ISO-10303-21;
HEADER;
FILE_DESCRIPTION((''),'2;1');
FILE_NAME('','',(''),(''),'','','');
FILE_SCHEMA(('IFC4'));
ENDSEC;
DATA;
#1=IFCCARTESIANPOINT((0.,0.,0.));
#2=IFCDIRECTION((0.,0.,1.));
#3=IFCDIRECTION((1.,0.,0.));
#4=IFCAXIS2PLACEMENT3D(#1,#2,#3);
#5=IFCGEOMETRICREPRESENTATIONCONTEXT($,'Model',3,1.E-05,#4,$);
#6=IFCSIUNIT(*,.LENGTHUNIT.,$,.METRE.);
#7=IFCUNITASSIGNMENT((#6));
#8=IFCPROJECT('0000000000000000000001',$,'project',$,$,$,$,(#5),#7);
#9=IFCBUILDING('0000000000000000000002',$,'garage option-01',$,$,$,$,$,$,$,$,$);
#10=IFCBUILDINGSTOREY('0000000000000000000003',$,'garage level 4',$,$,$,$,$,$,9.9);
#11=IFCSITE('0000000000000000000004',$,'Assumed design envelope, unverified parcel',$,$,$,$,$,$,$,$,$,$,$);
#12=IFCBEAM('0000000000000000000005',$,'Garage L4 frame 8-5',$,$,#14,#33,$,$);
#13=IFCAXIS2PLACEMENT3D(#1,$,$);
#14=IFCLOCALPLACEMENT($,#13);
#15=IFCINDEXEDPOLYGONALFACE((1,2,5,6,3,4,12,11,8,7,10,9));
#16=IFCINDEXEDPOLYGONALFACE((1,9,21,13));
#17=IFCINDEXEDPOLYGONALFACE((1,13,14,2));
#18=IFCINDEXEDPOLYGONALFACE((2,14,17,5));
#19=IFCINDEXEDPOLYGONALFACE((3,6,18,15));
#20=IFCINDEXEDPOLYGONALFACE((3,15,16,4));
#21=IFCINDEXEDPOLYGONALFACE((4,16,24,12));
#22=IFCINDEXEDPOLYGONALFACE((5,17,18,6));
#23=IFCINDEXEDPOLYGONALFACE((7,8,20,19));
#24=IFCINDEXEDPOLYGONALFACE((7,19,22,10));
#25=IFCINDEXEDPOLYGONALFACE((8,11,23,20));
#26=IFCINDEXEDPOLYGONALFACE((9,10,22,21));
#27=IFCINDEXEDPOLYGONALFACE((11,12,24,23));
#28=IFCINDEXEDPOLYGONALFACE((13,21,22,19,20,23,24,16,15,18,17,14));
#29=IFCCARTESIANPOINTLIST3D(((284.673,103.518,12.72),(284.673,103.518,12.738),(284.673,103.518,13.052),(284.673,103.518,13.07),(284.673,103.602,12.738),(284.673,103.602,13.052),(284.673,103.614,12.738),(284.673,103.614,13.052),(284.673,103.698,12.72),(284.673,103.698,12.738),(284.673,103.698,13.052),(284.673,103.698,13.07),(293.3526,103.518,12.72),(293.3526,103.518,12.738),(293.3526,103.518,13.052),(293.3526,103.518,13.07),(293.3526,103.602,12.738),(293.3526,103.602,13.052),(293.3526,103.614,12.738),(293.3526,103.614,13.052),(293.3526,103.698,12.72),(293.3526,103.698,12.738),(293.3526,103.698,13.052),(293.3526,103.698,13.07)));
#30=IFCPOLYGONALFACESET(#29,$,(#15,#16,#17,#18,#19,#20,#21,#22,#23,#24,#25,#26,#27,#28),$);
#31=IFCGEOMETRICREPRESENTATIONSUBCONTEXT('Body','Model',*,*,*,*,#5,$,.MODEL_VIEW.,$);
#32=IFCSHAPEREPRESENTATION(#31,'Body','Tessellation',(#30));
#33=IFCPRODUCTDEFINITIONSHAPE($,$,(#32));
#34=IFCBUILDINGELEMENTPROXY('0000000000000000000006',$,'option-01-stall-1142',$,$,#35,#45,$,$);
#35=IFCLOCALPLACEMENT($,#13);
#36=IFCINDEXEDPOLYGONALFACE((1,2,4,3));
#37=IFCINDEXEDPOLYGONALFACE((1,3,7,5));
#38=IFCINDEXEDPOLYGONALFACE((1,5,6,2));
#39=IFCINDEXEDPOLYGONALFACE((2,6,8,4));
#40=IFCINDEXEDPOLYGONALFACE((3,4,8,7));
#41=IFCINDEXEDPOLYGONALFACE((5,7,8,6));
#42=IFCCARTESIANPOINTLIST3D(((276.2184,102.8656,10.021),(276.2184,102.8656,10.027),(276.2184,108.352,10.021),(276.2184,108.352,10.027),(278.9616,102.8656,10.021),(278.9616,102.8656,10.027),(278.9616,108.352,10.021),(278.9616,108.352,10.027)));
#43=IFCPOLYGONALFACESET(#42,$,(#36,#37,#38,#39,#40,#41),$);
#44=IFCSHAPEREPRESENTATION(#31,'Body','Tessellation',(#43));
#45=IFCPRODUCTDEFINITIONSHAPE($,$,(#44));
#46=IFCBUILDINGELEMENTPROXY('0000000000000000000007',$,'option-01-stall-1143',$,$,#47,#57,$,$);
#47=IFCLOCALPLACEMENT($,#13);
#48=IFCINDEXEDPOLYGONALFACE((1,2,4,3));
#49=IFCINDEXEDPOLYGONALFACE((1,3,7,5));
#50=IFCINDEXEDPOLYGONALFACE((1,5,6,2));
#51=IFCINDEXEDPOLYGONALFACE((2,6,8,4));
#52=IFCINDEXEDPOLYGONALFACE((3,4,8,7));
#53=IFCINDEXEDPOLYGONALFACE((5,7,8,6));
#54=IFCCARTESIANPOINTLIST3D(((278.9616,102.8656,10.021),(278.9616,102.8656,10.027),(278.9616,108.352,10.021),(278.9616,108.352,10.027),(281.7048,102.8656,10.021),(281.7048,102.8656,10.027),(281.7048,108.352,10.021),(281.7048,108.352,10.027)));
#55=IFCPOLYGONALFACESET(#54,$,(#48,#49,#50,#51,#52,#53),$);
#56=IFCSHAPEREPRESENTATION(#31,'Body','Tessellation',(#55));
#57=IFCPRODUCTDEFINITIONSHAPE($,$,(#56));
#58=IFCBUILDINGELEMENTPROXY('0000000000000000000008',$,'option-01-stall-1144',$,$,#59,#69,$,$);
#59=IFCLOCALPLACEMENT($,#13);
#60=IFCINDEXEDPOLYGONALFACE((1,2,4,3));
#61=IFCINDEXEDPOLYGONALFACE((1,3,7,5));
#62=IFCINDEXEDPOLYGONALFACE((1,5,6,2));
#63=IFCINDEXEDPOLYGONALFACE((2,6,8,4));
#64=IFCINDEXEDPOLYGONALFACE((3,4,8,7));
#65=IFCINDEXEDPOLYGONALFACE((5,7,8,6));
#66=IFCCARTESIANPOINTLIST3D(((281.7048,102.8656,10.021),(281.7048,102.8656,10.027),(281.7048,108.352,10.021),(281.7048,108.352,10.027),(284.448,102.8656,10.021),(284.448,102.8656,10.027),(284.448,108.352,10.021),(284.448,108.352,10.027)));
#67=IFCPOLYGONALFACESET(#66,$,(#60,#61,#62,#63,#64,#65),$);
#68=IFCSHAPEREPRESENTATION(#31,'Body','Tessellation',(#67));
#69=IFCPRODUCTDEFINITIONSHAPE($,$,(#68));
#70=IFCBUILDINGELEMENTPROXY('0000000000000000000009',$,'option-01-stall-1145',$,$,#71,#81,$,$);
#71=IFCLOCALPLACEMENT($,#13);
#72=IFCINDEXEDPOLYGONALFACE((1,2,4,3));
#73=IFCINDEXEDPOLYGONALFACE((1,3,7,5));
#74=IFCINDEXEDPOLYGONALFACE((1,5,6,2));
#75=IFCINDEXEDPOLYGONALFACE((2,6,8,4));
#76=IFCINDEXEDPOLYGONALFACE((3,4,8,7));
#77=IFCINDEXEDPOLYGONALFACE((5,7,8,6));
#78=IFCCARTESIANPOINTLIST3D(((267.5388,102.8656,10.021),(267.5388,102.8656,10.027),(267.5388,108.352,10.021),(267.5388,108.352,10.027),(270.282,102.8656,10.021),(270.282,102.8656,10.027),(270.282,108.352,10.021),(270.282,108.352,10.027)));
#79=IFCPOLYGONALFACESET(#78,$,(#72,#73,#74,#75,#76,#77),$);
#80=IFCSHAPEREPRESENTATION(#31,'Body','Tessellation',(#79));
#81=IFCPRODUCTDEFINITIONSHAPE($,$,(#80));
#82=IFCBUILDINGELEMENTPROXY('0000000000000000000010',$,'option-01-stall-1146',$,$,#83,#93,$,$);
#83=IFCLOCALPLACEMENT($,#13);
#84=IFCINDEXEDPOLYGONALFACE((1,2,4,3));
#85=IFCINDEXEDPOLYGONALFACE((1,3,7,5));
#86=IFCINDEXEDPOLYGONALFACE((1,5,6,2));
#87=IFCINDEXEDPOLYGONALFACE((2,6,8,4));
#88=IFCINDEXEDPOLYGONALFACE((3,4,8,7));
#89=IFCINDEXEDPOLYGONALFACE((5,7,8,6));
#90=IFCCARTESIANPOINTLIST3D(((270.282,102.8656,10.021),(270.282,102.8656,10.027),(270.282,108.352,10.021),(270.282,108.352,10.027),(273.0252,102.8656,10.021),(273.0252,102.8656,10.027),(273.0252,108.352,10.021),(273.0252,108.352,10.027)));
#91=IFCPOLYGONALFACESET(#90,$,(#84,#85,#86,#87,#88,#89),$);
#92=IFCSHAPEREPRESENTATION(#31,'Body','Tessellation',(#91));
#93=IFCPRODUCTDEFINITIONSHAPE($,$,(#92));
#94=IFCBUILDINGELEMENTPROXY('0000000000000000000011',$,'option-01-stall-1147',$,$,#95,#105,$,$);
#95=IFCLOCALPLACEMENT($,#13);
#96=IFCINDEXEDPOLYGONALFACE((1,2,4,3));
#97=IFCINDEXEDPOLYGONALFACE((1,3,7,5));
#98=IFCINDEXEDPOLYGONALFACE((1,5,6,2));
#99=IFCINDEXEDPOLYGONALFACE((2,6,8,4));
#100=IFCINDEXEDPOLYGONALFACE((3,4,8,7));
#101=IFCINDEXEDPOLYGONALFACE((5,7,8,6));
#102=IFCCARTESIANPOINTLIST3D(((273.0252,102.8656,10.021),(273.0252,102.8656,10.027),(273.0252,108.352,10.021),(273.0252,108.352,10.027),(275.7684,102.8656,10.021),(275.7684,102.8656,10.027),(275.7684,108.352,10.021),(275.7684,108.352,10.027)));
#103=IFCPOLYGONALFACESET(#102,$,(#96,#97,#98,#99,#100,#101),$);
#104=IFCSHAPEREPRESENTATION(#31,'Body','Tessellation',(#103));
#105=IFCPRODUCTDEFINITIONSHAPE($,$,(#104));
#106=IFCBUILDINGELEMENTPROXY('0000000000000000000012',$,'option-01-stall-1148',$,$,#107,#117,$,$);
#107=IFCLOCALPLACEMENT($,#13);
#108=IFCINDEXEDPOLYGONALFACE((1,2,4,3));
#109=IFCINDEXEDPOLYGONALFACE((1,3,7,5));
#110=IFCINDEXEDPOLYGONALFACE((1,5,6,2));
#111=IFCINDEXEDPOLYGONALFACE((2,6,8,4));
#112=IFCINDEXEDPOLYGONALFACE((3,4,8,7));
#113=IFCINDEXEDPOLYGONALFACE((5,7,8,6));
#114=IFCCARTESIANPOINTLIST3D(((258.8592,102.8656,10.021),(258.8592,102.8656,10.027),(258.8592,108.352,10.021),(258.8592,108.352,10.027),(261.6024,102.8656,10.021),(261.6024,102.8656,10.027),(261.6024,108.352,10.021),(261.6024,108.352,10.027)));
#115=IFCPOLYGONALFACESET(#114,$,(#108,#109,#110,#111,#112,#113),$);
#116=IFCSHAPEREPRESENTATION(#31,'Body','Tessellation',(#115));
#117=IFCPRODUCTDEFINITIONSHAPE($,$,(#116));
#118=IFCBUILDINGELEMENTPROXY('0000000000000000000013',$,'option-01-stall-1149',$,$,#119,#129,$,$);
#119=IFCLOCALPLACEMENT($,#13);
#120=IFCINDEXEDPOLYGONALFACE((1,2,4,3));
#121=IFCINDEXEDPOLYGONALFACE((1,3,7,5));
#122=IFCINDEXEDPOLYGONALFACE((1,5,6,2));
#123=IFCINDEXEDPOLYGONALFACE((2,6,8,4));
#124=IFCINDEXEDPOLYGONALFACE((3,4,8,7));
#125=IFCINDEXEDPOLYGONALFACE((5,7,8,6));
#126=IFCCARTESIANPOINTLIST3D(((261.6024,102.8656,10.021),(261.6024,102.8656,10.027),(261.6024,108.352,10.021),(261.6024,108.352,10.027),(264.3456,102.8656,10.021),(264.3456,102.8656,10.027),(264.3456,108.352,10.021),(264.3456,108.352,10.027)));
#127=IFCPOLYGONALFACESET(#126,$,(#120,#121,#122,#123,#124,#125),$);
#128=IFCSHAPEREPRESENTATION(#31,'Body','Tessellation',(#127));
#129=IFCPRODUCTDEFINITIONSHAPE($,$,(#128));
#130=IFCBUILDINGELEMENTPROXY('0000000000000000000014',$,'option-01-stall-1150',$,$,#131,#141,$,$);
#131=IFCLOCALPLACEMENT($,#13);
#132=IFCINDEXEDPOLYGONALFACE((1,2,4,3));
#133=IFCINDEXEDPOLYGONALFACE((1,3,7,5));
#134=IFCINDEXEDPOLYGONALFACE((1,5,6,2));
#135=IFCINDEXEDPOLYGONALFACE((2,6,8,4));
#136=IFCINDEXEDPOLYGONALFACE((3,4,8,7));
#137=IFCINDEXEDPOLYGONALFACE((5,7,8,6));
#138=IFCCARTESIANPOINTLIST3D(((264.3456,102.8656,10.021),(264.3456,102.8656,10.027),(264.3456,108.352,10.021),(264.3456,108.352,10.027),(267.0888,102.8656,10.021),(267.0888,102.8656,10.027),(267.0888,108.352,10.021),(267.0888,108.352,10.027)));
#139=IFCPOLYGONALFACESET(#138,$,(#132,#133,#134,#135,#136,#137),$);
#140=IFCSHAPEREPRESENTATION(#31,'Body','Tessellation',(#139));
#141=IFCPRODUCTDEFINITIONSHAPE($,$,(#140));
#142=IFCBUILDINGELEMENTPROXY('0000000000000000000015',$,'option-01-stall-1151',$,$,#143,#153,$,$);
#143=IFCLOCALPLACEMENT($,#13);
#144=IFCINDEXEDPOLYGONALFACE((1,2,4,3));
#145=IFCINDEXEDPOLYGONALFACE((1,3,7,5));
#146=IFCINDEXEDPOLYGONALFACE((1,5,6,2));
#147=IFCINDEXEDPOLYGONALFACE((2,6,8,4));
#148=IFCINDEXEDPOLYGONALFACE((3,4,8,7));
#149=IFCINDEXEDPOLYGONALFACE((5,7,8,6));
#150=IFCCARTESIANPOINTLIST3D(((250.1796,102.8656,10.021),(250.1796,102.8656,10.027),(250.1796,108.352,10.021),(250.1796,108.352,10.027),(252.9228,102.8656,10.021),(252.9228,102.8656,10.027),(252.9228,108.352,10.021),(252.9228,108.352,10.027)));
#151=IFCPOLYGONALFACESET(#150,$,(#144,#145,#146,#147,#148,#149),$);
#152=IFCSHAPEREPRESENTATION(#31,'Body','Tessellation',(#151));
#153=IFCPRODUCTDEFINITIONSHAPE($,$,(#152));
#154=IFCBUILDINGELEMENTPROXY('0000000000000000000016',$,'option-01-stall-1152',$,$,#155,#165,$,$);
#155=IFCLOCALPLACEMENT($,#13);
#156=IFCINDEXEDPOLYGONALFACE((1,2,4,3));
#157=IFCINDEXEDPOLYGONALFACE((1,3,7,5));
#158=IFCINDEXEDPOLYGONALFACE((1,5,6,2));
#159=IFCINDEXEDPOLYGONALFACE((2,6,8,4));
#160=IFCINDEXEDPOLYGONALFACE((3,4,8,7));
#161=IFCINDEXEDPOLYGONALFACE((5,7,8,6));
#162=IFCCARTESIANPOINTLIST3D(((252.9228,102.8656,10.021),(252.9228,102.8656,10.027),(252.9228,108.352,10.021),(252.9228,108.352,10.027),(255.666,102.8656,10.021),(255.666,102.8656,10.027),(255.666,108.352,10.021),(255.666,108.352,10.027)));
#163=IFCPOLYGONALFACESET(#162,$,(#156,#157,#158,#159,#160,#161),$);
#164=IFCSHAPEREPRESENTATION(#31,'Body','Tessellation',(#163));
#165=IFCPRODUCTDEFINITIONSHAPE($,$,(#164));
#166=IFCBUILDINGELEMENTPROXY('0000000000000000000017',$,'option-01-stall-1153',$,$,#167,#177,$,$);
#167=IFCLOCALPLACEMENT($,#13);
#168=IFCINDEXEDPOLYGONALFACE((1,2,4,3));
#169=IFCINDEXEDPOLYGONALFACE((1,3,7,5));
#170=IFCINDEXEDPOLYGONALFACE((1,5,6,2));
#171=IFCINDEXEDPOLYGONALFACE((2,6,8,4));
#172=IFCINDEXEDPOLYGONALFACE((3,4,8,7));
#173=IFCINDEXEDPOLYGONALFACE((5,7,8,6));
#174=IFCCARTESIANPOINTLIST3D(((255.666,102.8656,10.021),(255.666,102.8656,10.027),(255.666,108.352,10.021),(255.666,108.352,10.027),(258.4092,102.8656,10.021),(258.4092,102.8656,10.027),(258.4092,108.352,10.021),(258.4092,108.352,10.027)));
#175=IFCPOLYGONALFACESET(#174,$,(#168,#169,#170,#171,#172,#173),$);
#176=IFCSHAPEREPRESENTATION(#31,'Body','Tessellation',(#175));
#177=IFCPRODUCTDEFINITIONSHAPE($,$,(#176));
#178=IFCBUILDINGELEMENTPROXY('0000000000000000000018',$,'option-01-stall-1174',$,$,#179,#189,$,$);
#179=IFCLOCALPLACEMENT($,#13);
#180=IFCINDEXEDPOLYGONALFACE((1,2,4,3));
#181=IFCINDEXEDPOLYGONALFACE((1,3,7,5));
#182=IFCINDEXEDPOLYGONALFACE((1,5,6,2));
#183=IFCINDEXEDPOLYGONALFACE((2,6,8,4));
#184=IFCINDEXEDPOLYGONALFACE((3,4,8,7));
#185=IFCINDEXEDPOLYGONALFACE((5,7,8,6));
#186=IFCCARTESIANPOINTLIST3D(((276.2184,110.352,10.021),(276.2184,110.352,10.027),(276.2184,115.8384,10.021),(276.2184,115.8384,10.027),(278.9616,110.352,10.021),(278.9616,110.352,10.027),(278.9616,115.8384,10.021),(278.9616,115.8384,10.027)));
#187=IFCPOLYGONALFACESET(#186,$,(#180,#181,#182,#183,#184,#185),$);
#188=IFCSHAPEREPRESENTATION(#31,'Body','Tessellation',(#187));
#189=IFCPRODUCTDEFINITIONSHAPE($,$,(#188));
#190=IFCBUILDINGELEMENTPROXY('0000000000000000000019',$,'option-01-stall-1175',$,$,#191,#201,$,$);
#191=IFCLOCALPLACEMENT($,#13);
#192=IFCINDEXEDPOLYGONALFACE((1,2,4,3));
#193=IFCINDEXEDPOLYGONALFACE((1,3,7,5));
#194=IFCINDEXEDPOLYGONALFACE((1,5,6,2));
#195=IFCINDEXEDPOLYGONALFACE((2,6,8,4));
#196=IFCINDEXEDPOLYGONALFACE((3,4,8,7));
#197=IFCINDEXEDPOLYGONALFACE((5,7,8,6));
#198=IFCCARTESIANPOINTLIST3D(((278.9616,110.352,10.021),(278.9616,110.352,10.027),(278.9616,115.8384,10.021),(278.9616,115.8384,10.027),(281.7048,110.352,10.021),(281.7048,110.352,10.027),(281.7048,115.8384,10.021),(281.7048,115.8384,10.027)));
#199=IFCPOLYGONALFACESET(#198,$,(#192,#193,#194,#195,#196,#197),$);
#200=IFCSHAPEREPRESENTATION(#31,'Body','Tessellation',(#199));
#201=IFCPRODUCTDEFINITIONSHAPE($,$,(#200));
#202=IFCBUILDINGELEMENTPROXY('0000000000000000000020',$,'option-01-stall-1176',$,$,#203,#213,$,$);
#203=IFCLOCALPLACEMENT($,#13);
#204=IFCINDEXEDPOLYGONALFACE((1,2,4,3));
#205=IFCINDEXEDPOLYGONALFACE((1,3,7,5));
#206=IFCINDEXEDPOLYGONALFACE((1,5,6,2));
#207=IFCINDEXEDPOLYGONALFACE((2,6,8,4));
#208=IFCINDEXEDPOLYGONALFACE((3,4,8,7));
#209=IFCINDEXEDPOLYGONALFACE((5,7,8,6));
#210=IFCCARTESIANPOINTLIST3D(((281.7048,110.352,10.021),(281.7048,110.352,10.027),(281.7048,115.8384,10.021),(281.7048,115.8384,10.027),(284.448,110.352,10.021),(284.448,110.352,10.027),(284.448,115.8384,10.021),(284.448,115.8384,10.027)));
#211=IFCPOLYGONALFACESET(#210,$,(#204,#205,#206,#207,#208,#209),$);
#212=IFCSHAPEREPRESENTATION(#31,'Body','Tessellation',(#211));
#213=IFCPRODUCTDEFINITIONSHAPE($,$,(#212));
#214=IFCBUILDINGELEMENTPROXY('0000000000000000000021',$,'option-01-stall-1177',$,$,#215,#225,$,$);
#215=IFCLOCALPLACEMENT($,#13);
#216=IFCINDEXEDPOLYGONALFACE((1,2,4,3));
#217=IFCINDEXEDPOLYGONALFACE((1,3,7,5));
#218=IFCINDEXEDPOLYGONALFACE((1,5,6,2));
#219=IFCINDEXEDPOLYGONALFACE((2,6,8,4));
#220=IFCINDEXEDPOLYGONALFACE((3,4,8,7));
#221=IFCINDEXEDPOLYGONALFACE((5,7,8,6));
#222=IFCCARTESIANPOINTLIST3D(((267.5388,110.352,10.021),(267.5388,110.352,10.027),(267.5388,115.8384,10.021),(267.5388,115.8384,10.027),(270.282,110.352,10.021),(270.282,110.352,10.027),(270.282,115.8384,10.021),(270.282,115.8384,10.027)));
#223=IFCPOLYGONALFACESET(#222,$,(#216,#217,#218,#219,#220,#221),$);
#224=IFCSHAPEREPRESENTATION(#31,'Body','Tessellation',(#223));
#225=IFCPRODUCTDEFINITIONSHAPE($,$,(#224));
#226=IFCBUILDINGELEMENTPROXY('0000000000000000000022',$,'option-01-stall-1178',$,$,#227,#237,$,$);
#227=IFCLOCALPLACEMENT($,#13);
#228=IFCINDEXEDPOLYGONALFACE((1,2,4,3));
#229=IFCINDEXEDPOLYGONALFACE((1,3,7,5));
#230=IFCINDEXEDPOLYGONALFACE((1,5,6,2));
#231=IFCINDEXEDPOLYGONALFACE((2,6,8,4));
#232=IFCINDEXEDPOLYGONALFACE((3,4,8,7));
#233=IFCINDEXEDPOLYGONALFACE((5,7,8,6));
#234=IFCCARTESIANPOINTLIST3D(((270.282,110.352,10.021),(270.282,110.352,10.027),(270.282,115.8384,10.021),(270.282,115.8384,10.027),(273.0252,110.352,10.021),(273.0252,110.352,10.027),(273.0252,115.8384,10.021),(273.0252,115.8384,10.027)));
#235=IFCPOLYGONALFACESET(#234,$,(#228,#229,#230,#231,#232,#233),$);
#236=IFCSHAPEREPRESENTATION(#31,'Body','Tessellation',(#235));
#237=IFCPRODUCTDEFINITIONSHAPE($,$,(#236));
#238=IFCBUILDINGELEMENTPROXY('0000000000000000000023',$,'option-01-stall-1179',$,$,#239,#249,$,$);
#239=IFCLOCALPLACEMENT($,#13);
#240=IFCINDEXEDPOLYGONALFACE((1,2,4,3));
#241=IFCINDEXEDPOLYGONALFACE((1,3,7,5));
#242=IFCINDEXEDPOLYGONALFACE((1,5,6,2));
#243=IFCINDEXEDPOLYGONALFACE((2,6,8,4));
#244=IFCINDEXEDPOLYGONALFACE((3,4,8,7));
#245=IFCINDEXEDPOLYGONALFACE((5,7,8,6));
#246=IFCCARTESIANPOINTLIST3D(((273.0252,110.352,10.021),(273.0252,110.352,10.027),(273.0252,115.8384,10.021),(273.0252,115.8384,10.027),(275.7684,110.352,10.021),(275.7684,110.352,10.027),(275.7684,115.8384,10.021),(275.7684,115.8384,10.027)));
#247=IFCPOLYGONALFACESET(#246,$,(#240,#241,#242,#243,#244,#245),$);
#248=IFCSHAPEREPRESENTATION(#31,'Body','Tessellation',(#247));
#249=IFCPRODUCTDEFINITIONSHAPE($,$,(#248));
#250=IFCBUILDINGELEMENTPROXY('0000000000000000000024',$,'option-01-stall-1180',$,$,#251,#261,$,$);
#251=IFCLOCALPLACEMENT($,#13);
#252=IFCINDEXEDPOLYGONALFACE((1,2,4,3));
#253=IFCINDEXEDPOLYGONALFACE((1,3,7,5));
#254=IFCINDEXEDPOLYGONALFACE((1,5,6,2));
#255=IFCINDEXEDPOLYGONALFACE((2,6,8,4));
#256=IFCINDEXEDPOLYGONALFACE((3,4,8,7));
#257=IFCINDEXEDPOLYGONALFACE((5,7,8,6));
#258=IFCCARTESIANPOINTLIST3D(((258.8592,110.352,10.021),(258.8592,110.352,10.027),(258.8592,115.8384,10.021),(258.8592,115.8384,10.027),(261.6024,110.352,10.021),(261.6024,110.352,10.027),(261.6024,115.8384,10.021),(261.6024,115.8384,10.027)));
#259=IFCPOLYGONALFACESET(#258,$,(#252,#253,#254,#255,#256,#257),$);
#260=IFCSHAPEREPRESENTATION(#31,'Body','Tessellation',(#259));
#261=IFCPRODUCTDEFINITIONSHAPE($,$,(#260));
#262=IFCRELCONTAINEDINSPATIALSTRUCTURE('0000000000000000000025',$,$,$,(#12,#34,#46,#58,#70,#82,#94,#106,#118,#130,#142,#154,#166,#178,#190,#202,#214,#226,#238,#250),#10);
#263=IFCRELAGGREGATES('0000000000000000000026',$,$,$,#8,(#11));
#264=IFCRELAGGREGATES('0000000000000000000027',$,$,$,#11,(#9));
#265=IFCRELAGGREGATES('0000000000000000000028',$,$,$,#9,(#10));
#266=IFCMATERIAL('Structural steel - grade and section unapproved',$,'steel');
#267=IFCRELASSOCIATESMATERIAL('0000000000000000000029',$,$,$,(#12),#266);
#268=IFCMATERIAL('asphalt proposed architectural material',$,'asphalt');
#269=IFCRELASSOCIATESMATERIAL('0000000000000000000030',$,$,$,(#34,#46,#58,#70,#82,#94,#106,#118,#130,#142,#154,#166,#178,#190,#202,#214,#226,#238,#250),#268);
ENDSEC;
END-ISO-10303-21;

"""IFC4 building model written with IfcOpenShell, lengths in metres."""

from ifc_helpers import new_model, si_unit, frame, origin_with_axes, place, context, subcontext, project, spatial, rectangle, i_section, extrude, material, element, save


model = new_model("IFC4")

# Units and contexts
model_context = context("Model", 3, precision=1e-05, world=origin_with_axes())
body_context = subcontext(model_context, "Body", "Model", "MODEL_VIEW")
ifc_project = project(units=[si_unit("LENGTHUNIT", "METRE")], contexts=[model_context])

# Site, building, storey
site = spatial("IfcSite", under=ifc_project, Name="Assumed design envelope, unverified parcel")
building = spatial("IfcBuilding", under=site, Name="garage option-01")
storey = spatial("IfcBuildingStorey", under=building, Name="garage level 4", Elevation=9.9)

# Beam
ifc_material_1 = material(Name="Structural steel - grade and section unapproved", Category="steel")
beam_placement = place(None, frame((284.673, 103.608, 12.895), z_axis=(1.0, 0.0, 0.0), x_axis=(0.0, 1.0, 0.0)))
element("IfcBeam", 1, at=beam_placement, inside=storey, material=ifc_material_1, Name="Garage L4 frame 8-5", context=body_context, shape_type="SweptSolid", body=[
    extrude(i_section(OverallWidth=0.18, OverallDepth=0.35, WebThickness=0.012, FlangeThickness=0.018, FilletRadius=0.0), origin_with_axes(), (0.0, 0.0, 1.0), 8.6796),
])

# Building element proxies
ifc_material_2 = material(Name="asphalt proposed architectural material", Category="asphalt")
for number, where, z_axis, x_axis, name in (
    (2, (277.59, 105.6088, 10.021), (0.0, 0.0, 1.0), (1.0, 0.0, 0.0), "option-01-stall-1142"),
    (3, (280.3332, 105.6088, 10.021), (0.0, 0.0, 1.0), (1.0, 0.0, 0.0), "option-01-stall-1143"),
    (4, (283.0764, 105.6088, 10.021), (0.0, 0.0, 1.0), (1.0, 0.0, 0.0), "option-01-stall-1144"),
    (5, (268.9104, 105.6088, 10.021), (0.0, 0.0, 1.0), (1.0, 0.0, 0.0), "option-01-stall-1145"),
    (6, (271.6536, 105.6088, 10.021), (0.0, 0.0, 1.0), (1.0, 0.0, 0.0), "option-01-stall-1146"),
    (7, (274.3968, 105.6088, 10.021), (0.0, 0.0, 1.0), (1.0, 0.0, 0.0), "option-01-stall-1147"),
    (8, (260.2308, 105.6088, 10.021), (0.0, 0.0, 1.0), (1.0, 0.0, 0.0), "option-01-stall-1148"),
    (9, (262.974, 105.6088, 10.021), (0.0, 0.0, 1.0), (1.0, 0.0, 0.0), "option-01-stall-1149"),
    (10, (265.7172, 105.6088, 10.021), (0.0, 0.0, 1.0), (1.0, 0.0, 0.0), "option-01-stall-1150"),
    (11, (251.5512, 105.6088, 10.021), (0.0, 0.0, 1.0), (1.0, 0.0, 0.0), "option-01-stall-1151"),
    (12, (254.2944, 105.6088, 10.021), (0.0, 0.0, 1.0), (1.0, 0.0, 0.0), "option-01-stall-1152"),
    (13, (257.0376, 105.6088, 10.021), (0.0, 0.0, 1.0), (1.0, 0.0, 0.0), "option-01-stall-1153"),
    (14, (277.59, 113.0952, 10.021), (0.0, 0.0, 1.0), (1.0, 0.0, 0.0), "option-01-stall-1174"),
    (15, (280.3332, 113.0952, 10.021), (0.0, 0.0, 1.0), (1.0, 0.0, 0.0), "option-01-stall-1175"),
    (16, (283.0764, 113.0952, 10.021), (0.0, 0.0, 1.0), (1.0, 0.0, 0.0), "option-01-stall-1176"),
    (17, (268.9104, 113.0952, 10.021), (0.0, 0.0, 1.0), (1.0, 0.0, 0.0), "option-01-stall-1177"),
    (18, (271.6536, 113.0952, 10.021), (0.0, 0.0, 1.0), (1.0, 0.0, 0.0), "option-01-stall-1178"),
    (19, (274.3968, 113.0952, 10.021), (0.0, 0.0, 1.0), (1.0, 0.0, 0.0), "option-01-stall-1179"),
    (20, (260.2308, 113.0952, 10.021), (0.0, 0.0, 1.0), (1.0, 0.0, 0.0), "option-01-stall-1180"),
):
    element("IfcBuildingElementProxy", number, at=place(None, frame(where, z_axis=z_axis, x_axis=x_axis)), inside=storey, material=ifc_material_2, Name=name, context=body_context, shape_type="SweptSolid", body=[
        extrude(rectangle(XDim=2.7432, YDim=5.4864), origin_with_axes(), (0.0, 0.0, 1.0), 0.006),
    ])

save(model, "model.ifc")
